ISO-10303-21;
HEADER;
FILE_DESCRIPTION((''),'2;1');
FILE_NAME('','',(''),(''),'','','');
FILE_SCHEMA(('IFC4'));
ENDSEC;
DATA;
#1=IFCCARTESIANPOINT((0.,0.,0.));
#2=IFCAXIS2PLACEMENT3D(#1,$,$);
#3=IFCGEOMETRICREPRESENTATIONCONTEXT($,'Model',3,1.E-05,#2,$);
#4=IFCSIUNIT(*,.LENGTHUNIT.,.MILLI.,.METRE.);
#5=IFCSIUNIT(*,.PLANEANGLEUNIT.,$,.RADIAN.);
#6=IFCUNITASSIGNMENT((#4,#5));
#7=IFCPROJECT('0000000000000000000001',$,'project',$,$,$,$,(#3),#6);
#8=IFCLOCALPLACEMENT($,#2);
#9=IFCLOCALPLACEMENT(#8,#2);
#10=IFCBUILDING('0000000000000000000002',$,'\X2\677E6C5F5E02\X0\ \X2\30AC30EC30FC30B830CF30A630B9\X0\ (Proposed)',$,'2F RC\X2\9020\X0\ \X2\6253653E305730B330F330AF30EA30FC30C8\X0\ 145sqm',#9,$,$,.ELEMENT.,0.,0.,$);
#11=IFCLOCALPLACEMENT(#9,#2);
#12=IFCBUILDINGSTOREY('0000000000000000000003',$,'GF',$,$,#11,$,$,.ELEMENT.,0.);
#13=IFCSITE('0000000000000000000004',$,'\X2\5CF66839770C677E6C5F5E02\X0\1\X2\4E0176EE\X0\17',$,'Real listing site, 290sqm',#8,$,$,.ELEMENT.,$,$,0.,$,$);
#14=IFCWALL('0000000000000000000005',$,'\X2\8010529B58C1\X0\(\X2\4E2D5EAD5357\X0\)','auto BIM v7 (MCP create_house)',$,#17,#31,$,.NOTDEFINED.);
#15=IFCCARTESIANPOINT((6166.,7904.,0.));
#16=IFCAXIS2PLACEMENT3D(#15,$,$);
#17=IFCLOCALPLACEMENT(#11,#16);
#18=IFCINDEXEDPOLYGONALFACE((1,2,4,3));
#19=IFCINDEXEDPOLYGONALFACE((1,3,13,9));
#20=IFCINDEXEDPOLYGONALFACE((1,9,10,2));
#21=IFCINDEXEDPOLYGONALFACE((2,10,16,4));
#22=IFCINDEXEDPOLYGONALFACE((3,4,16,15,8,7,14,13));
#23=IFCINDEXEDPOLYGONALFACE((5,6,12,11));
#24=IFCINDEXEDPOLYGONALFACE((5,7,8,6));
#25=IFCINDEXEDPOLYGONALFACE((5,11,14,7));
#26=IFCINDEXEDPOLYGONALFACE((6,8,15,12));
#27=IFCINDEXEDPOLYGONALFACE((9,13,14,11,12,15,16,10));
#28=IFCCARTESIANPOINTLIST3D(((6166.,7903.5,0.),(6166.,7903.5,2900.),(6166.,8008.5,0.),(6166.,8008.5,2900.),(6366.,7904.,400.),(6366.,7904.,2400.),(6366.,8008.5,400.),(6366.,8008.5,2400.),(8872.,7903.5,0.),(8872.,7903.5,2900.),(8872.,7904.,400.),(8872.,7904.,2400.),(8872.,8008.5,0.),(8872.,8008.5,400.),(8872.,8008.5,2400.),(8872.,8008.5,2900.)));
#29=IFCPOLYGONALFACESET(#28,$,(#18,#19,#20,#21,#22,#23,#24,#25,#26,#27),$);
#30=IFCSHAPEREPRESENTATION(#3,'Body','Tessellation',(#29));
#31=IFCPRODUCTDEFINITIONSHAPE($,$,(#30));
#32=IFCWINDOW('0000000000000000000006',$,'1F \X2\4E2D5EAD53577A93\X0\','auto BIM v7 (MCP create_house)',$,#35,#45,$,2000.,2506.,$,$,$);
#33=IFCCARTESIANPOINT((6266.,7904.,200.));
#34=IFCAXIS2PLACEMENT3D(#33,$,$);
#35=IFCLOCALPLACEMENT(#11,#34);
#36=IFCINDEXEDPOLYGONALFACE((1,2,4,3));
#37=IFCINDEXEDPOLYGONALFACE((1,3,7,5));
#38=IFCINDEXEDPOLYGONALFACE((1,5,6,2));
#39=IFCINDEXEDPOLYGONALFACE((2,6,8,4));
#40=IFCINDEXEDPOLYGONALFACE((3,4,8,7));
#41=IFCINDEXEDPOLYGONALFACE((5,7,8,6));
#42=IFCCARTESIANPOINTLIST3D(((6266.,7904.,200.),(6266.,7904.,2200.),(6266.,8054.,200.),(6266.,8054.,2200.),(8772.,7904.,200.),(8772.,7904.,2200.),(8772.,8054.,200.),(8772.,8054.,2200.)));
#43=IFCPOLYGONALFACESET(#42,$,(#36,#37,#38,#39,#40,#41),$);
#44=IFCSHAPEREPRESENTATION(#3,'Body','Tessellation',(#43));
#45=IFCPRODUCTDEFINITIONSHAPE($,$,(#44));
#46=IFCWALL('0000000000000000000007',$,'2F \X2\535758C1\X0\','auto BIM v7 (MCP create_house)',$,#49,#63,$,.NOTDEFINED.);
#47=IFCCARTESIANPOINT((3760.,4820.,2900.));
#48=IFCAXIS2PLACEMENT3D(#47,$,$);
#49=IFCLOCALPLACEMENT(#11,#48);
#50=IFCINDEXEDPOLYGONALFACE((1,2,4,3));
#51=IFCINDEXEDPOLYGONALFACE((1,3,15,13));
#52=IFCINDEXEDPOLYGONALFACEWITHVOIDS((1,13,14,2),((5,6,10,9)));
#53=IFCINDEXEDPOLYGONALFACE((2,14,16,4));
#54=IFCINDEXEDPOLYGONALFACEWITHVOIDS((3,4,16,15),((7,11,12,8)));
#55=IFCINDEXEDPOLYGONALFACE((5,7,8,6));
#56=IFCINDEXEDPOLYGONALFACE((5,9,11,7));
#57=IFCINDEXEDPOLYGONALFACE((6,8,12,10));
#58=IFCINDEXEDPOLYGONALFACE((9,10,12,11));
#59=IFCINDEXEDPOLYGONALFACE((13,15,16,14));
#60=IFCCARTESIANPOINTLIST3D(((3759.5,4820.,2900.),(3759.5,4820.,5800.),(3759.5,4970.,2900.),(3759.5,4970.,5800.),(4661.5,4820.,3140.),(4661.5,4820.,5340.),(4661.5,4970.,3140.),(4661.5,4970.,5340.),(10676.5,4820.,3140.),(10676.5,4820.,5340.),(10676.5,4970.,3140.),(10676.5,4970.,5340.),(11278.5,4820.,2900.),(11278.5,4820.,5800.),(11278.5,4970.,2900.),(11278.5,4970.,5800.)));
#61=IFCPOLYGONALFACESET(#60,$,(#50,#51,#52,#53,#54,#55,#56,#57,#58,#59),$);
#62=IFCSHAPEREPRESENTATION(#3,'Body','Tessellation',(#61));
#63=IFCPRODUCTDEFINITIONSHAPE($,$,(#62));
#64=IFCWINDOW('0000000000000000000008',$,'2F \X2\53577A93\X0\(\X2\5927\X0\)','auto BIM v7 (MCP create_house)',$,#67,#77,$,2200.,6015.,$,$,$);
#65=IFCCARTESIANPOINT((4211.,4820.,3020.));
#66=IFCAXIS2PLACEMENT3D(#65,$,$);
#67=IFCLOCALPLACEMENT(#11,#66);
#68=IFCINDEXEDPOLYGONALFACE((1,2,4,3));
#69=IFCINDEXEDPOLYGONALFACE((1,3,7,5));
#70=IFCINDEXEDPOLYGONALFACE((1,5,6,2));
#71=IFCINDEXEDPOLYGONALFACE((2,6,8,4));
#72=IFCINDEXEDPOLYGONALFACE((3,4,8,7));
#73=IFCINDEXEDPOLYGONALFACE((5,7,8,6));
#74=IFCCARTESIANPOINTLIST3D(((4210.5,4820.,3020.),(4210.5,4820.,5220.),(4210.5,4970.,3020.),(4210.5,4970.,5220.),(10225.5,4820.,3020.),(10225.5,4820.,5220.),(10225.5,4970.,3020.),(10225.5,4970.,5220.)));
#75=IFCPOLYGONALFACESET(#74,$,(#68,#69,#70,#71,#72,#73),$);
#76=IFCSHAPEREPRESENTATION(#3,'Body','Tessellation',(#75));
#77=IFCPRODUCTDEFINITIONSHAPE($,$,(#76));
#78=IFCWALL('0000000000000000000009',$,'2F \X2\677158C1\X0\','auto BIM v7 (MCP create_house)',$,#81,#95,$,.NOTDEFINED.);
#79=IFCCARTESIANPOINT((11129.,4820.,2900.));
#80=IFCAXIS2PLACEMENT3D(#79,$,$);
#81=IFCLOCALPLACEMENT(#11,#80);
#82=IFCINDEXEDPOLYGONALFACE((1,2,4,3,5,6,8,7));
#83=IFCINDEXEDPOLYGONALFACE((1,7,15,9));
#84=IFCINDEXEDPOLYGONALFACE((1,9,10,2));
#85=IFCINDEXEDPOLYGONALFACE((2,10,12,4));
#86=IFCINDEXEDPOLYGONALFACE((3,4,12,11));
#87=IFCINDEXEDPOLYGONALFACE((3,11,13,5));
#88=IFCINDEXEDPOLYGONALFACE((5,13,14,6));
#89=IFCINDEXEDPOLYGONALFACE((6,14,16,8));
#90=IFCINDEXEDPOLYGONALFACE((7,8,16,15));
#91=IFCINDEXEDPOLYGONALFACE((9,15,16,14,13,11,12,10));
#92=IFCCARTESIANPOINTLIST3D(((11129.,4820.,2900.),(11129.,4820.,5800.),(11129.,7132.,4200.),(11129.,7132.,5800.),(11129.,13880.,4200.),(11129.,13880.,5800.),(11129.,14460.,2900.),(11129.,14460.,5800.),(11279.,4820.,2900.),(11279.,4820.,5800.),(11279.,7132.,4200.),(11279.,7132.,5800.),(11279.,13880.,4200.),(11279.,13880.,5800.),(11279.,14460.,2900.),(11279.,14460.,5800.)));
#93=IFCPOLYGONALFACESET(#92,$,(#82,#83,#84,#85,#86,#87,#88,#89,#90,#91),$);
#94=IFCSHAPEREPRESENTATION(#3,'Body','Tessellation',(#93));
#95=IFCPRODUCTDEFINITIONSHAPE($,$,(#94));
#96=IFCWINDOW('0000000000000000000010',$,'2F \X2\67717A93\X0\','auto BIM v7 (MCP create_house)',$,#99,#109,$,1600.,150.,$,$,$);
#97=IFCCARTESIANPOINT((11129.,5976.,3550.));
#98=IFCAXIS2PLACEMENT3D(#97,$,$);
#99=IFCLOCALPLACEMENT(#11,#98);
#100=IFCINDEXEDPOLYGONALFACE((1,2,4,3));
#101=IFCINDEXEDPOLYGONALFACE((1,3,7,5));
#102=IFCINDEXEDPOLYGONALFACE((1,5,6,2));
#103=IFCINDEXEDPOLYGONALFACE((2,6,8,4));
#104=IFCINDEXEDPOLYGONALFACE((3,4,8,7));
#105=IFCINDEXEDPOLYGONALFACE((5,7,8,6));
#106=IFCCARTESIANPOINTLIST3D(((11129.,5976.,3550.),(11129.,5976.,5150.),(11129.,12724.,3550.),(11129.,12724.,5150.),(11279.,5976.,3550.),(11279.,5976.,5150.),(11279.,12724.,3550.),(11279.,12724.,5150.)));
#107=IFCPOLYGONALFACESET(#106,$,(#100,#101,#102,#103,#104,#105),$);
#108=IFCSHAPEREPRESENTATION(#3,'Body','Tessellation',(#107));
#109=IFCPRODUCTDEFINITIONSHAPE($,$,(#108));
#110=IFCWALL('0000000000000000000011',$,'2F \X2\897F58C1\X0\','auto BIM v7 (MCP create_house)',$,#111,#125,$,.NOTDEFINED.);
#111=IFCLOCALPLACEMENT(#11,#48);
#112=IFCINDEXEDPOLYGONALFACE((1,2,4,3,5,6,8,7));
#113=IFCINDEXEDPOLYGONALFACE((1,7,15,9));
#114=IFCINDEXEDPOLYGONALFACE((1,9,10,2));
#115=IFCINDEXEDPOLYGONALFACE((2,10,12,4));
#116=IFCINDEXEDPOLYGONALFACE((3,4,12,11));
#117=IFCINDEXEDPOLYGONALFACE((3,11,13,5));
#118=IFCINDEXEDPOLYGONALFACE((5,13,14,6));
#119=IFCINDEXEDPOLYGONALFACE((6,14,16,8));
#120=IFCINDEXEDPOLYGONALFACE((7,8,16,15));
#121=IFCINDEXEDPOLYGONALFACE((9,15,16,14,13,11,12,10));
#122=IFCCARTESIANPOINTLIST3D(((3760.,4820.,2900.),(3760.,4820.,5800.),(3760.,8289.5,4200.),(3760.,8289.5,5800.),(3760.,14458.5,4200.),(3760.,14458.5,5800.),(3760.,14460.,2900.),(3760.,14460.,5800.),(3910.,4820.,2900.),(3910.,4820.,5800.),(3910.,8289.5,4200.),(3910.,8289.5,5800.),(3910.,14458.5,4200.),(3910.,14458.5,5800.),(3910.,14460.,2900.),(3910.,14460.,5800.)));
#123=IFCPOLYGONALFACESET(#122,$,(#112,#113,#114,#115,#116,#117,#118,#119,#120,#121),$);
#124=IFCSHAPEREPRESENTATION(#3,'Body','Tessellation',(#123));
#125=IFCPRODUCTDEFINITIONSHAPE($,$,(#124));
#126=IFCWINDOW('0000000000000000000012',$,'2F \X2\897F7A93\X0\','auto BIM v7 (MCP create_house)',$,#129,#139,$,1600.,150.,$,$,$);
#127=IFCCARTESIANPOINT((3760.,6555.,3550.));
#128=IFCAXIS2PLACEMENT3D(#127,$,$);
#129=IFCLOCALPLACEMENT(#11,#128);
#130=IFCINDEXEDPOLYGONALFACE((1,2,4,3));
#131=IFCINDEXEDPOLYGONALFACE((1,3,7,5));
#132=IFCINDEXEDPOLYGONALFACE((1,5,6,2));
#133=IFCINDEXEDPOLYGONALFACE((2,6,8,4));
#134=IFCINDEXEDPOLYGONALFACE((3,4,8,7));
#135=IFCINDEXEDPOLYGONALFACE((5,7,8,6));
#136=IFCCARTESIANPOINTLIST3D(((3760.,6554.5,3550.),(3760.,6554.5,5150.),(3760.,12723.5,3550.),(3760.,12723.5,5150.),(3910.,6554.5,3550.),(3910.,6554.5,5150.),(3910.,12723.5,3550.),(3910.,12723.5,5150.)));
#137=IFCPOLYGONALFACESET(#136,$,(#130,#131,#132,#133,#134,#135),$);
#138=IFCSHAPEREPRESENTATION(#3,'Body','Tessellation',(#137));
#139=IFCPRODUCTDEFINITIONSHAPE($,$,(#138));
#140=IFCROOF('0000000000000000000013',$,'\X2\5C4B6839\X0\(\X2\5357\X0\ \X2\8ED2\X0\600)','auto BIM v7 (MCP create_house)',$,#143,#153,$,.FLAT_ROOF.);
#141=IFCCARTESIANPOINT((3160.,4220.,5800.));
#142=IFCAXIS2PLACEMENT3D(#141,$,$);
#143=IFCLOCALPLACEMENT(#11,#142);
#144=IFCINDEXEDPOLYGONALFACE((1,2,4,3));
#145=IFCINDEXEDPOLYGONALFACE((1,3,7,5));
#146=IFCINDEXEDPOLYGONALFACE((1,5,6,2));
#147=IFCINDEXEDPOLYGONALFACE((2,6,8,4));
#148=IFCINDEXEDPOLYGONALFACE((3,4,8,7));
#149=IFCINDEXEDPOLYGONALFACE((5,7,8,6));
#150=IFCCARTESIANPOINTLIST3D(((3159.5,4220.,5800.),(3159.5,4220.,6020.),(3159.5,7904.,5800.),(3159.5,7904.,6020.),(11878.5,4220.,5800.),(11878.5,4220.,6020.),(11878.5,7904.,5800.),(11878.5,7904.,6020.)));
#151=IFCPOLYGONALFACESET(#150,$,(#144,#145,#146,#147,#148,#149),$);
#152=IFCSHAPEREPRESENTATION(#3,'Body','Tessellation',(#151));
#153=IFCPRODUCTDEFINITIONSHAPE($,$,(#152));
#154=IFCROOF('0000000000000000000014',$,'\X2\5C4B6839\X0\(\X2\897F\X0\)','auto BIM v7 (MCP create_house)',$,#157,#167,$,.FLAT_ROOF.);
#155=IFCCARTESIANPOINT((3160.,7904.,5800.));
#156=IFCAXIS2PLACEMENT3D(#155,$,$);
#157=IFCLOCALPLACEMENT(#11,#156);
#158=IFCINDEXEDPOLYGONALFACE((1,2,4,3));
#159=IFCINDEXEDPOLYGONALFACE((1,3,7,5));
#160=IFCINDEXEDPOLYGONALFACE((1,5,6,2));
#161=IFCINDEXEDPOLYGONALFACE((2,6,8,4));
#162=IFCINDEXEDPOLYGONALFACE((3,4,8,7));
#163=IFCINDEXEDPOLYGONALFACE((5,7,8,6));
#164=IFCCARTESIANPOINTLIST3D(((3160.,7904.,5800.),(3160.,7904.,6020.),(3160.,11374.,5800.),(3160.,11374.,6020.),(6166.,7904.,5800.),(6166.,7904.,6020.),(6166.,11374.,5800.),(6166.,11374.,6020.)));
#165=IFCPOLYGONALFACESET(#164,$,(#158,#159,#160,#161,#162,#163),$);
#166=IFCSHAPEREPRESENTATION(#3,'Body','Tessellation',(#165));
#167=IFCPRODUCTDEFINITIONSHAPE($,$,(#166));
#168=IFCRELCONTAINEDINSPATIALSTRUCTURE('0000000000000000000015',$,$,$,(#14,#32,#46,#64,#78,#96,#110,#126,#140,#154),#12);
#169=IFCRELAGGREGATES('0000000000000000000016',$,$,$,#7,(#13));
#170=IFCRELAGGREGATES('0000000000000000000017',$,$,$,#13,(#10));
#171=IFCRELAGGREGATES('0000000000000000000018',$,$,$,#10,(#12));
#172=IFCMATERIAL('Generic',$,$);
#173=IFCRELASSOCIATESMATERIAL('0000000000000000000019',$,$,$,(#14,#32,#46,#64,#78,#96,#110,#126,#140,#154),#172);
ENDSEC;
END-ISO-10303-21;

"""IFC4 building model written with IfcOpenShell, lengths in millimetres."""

from ifc_helpers import new_model, si_unit, frame, frame_2d, origin, place, context, project, spatial, rectangle, extrude, material, element, fill, save


model = new_model("IFC4")

# Units and contexts
model_context = context("Model", 3, precision=1e-05, world=origin())
ifc_project = project(units=[si_unit("LENGTHUNIT", "METRE", prefix="MILLI"), si_unit("PLANEANGLEUNIT", "RADIAN")], contexts=[model_context])

# Site, building, storey
site_placement = place(None, origin())
site = spatial("IfcSite", under=ifc_project, at=site_placement, Name="島根県松江市1丁目17", ObjectType="Real listing site, 290sqm", CompositionType="ELEMENT", RefElevation=0.0)
building_placement = place(site_placement, origin())
building = spatial("IfcBuilding", under=site, at=building_placement, Name="松江市 ガレージハウス (Proposed)", ObjectType="2F RC造 打放しコンクリート 145sqm", CompositionType="ELEMENT", ElevationOfRefHeight=0.0, ElevationOfTerrain=0.0)
storey_placement = place(building_placement, origin())
storey = spatial("IfcBuildingStorey", under=building, at=storey_placement, Name="GF", CompositionType="ELEMENT", Elevation=0.0)

# Shared definitions
ifc_material = material(Name="Generic")

# Wall, opening, window
wall_1_placement = place(storey_placement, frame((6166.0, 7904.0, 0.0)))
wall_1 = element("IfcWall", 1, at=wall_1_placement, inside=storey, material=ifc_material, Name="耐力壁(中庭南)", Description="auto BIM v7 (MCP create_house)", PredefinedType="NOTDEFINED", context=model_context, shape_type="SweptSolid", body=[
    extrude(rectangle(XDim=2706.0, YDim=105.0, at=frame_2d((1353.0, 52.0))), frame((6166.0, 7904.0, 0.0)), (0.0, 0.0, 1.0), 2900.0),
])
opening_1_placement = place(storey_placement, frame((6266.0, 7904.0, 200.0)))
opening_1 = element("IfcOpeningElement", 2, at=opening_1_placement, cuts=wall_1, PredefinedType="NOTDEFINED", context=model_context, shape_type="SweptSolid", body=[
    extrude(rectangle(XDim=2506.0, YDim=150.0, at=frame_2d((1253.0, 75.0))), frame((6266.0, 7904.0, 200.0)), (0.0, 0.0, 1.0), 2000.0),
])
window_1_placement = place(storey_placement, frame((6266.0, 7904.0, 200.0)))
window_1 = element("IfcWindow", 3, at=window_1_placement, inside=storey, material=ifc_material, Name="1F 中庭南窓", Description="auto BIM v7 (MCP create_house)", OverallHeight=2000.0, OverallWidth=2506.0, context=model_context, shape_type="SweptSolid", body=[
    extrude(rectangle(XDim=2506.0, YDim=150.0, at=frame_2d((1253.0, 75.0))), frame((6266.0, 7904.0, 200.0)), (0.0, 0.0, 1.0), 2000.0),
])
fill(opening_1, window_1)

# Walls, openings, windows
wall_2_placement = place(storey_placement, frame((3760.0, 4820.0, 2900.0)))
wall_2 = element("IfcWall", 4, at=wall_2_placement, inside=storey, material=ifc_material, Name="2F 南壁", Description="auto BIM v7 (MCP create_house)", PredefinedType="NOTDEFINED", context=model_context, shape_type="SweptSolid", body=[
    extrude(rectangle(XDim=7519.0, YDim=150.0, at=frame_2d((3759.0, 75.0))), frame((3760.0, 4820.0, 2900.0)), (0.0, 0.0, 1.0), 2900.0),
])
opening_2_placement = place(storey_placement, frame((4211.0, 4820.0, 3020.0)))
opening_2 = element("IfcOpeningElement", 5, at=opening_2_placement, cuts=wall_2, PredefinedType="NOTDEFINED", context=model_context, shape_type="SweptSolid", body=[
    extrude(rectangle(XDim=6015.0, YDim=150.0, at=frame_2d((3007.0, 75.0))), frame((4211.0, 4820.0, 3020.0)), (0.0, 0.0, 1.0), 2200.0),
])
window_2_placement = place(storey_placement, frame((4211.0, 4820.0, 3020.0)))
window_2 = element("IfcWindow", 6, at=window_2_placement, inside=storey, material=ifc_material, Name="2F 南窓(大)", Description="auto BIM v7 (MCP create_house)", OverallHeight=2200.0, OverallWidth=6015.0, context=model_context, shape_type="SweptSolid", body=[
    extrude(rectangle(XDim=6015.0, YDim=150.0, at=frame_2d((3007.0, 75.0))), frame((4211.0, 4820.0, 3020.0)), (0.0, 0.0, 1.0), 2200.0),
])
fill(opening_2, window_2)
wall_3_placement = place(storey_placement, frame((11129.0, 4820.0, 2900.0)))
wall_3 = element("IfcWall", 7, at=wall_3_placement, inside=storey, material=ifc_material, Name="2F 東壁", Description="auto BIM v7 (MCP create_house)", PredefinedType="NOTDEFINED", context=model_context, shape_type="SweptSolid", body=[
    extrude(rectangle(XDim=150.0, YDim=9640.0, at=frame_2d((75.0, 4820.0))), frame((11129.0, 4820.0, 2900.0)), (0.0, 0.0, 1.0), 2900.0),
])
opening_3_placement = place(storey_placement, frame((11129.0, 5976.0, 3550.0)))
opening_3 = element("IfcOpeningElement", 8, at=opening_3_placement, cuts=wall_3, PredefinedType="NOTDEFINED", context=model_context, shape_type="SweptSolid", body=[
    extrude(rectangle(XDim=150.0, YDim=6748.0, at=frame_2d((75.0, 3374.0))), frame((11129.0, 5976.0, 3550.0)), (0.0, 0.0, 1.0), 1600.0),
])
window_3_placement = place(storey_placement, frame((11129.0, 5976.0, 3550.0)))
window_3 = element("IfcWindow", 9, at=window_3_placement, inside=storey, material=ifc_material, Name="2F 東窓", Description="auto BIM v7 (MCP create_house)", OverallHeight=1600.0, OverallWidth=150.0, context=model_context, shape_type="SweptSolid", body=[
    extrude(rectangle(XDim=150.0, YDim=6748.0, at=frame_2d((75.0, 3374.0))), frame((11129.0, 5976.0, 3550.0)), (0.0, 0.0, 1.0), 1600.0),
])
fill(opening_3, window_3)
wall_4_placement = place(storey_placement, frame((3760.0, 4820.0, 2900.0)))
wall_4 = element("IfcWall", 10, at=wall_4_placement, inside=storey, material=ifc_material, Name="2F 西壁", Description="auto BIM v7 (MCP create_house)", PredefinedType="NOTDEFINED", context=model_context, shape_type="SweptSolid", body=[
    extrude(rectangle(XDim=150.0, YDim=9640.0, at=frame_2d((75.0, 4820.0))), frame((3760.0, 4820.0, 2900.0)), (0.0, 0.0, 1.0), 2900.0),
])
opening_4_placement = place(storey_placement, frame((3760.0, 6555.0, 3550.0)))
opening_4 = element("IfcOpeningElement", 11, at=opening_4_placement, cuts=wall_4, PredefinedType="NOTDEFINED", context=model_context, shape_type="SweptSolid", body=[
    extrude(rectangle(XDim=150.0, YDim=6169.0, at=frame_2d((75.0, 3084.0))), frame((3760.0, 6555.0, 3550.0)), (0.0, 0.0, 1.0), 1600.0),
])
window_4_placement = place(storey_placement, frame((3760.0, 6555.0, 3550.0)))
window_4 = element("IfcWindow", 12, at=window_4_placement, inside=storey, material=ifc_material, Name="2F 西窓", Description="auto BIM v7 (MCP create_house)", OverallHeight=1600.0, OverallWidth=150.0, context=model_context, shape_type="SweptSolid", body=[
    extrude(rectangle(XDim=150.0, YDim=6169.0, at=frame_2d((75.0, 3084.0))), frame((3760.0, 6555.0, 3550.0)), (0.0, 0.0, 1.0), 1600.0),
])
fill(opening_4, window_4)

# Roofs
roof_1_placement = place(storey_placement, frame((3160.0, 4220.0, 5800.0)))
element("IfcRoof", 13, at=roof_1_placement, inside=storey, material=ifc_material, Name="屋根(南 軒600)", Description="auto BIM v7 (MCP create_house)", PredefinedType="FLAT_ROOF", context=model_context, shape_type="SweptSolid", body=[
    extrude(rectangle(XDim=8719.0, YDim=3684.0, at=frame_2d((4359.0, 1842.0))), frame((3160.0, 4220.0, 5800.0)), (0.0, 0.0, 1.0), 220.0),
])
roof_2_placement = place(storey_placement, frame((3160.0, 7904.0, 5800.0)))
element("IfcRoof", 14, at=roof_2_placement, inside=storey, material=ifc_material, Name="屋根(西)", Description="auto BIM v7 (MCP create_house)", PredefinedType="FLAT_ROOF", context=model_context, shape_type="SweptSolid", body=[
    extrude(rectangle(XDim=3006.0, YDim=3470.0, at=frame_2d((1503.0, 1735.0))), frame((3160.0, 7904.0, 5800.0)), (0.0, 0.0, 1.0), 220.0),
])

save(model, "model.ifc")
